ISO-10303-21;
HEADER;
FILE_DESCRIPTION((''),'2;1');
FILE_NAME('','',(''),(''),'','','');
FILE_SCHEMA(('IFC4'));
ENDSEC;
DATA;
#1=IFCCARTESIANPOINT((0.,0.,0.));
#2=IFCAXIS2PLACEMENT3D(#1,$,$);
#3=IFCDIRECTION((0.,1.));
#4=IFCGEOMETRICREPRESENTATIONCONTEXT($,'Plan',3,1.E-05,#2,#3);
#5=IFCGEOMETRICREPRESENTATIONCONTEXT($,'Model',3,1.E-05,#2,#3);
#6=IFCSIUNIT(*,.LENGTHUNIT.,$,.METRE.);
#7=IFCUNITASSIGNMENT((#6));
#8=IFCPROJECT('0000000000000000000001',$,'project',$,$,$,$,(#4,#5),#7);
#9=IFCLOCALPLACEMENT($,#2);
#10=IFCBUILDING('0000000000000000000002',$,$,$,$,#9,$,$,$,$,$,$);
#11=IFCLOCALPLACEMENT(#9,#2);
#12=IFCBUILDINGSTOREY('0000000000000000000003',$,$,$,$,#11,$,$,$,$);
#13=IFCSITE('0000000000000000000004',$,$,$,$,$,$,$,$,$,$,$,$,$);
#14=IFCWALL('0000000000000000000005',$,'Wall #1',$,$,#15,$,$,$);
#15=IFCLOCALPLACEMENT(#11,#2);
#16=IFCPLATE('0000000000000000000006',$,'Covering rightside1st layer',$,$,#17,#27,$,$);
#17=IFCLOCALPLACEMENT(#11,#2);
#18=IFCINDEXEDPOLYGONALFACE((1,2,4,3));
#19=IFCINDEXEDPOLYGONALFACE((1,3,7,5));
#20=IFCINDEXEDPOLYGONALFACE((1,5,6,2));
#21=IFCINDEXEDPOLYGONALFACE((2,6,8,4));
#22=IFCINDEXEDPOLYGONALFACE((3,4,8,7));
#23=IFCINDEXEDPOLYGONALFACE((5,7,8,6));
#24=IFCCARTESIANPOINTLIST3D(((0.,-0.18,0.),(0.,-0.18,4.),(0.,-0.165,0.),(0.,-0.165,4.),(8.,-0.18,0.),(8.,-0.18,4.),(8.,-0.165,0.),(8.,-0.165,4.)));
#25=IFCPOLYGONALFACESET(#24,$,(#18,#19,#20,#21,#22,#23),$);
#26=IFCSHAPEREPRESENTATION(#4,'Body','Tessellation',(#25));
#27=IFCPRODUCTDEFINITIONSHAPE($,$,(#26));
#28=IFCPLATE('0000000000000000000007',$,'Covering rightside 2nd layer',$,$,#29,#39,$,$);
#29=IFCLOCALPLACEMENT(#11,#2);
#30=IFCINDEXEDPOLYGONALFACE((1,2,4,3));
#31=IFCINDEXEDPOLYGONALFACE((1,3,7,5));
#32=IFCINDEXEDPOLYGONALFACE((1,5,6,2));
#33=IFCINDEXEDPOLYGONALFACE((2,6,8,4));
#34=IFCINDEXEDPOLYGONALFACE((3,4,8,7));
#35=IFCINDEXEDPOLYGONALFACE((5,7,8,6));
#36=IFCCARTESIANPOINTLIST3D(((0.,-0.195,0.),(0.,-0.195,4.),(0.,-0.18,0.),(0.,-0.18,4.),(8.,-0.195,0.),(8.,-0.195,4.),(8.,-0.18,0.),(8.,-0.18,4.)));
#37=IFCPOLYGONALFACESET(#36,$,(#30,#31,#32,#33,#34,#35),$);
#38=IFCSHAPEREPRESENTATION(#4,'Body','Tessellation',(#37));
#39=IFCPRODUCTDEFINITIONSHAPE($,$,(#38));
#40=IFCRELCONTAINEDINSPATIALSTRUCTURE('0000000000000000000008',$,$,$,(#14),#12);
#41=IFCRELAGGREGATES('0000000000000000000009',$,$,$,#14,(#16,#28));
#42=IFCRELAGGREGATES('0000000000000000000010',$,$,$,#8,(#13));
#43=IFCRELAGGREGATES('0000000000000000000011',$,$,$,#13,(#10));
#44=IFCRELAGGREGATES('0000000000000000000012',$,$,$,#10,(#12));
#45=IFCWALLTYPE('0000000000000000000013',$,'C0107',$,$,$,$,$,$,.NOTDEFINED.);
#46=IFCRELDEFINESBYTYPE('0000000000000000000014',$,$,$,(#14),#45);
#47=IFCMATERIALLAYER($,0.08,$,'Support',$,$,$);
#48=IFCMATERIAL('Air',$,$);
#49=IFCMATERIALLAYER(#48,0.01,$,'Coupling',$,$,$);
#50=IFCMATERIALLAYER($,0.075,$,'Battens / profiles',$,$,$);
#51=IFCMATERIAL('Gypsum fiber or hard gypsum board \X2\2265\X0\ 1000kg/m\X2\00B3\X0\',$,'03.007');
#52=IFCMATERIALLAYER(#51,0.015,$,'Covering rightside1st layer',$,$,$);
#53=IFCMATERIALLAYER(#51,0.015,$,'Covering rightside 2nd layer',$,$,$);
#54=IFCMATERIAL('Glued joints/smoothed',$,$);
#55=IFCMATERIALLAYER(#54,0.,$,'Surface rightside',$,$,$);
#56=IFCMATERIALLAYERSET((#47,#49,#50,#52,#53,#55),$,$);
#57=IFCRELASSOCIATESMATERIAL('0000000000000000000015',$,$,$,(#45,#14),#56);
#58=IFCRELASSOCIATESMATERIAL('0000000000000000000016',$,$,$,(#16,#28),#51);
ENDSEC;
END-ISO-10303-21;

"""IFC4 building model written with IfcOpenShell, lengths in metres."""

from ifc_helpers import new_model, si_unit, direction, frame, frame_2d, origin, place, context, project, spatial, rectangle, extrude, material, layer, layer_set, type_object, element, aggregate, save


model = new_model("IFC4")

# Units and contexts
plan_context = context("Plan", 3, precision=1e-05, world=origin(), true_north=direction((0.0, 1.0)))
model_context = context("Model", 3, precision=1e-05, world=origin(), true_north=direction((0.0, 1.0)))
ifc_project = project(units=[si_unit("LENGTHUNIT", "METRE")], contexts=[plan_context, model_context])

# Site, building, storey
site = spatial("IfcSite", under=ifc_project)
building_placement = place(None, origin())
building = spatial("IfcBuilding", under=site, at=building_placement)
storey_placement = place(building_placement, origin())
storey = spatial("IfcBuildingStorey", under=building, at=storey_placement)

# Wall, plates
ifc_layer_1 = layer(None, 0.08, Name="Support")
ifc_material_1 = material(Name="Air")
ifc_layer_2 = layer(ifc_material_1, 0.01, Name="Coupling")
ifc_layer_3 = layer(None, 0.075, Name="Battens / profiles")
ifc_material_2 = material(Name="Gypsum fiber or hard gypsum board ≥ 1000kg/m³", Category="03.007")
ifc_layer_4 = layer(ifc_material_2, 0.015, Name="Covering rightside1st layer")
ifc_layer_5 = layer(ifc_material_2, 0.015, Name="Covering rightside 2nd layer")
ifc_material_3 = material(Name="Glued joints/smoothed")
ifc_layer_6 = layer(ifc_material_3, 0.0, Name="Surface rightside")
ifc_layer_set = layer_set([ifc_layer_1, ifc_layer_2, ifc_layer_3, ifc_layer_4, ifc_layer_5, ifc_layer_6])
wall_type = type_object("IfcWallType", Name="C0107", PredefinedType="NOTDEFINED", material=ifc_layer_set)
wall_placement = place(None, frame((0.0, 0.0, 0.0), z_axis=(0.0, -1.0, 0.0), x_axis=(1.0, 0.0, 0.0)))
wall = element("IfcWall", 1, at=wall_placement, inside=storey, type_object=wall_type, material=ifc_layer_set, Name="Wall #1")
plate_1_placement = place(wall_placement, origin())
plate_1 = element("IfcPlate", 2, at=plate_1_placement, material=ifc_material_2, Name="Covering rightside1st layer", context=plan_context, shape_type="SweptSolid", body=[
    extrude(rectangle(XDim=8.0, YDim=4.0, at=frame_2d((4.0, 2.0), x_axis=(1.0, 0.0))), frame((0.0, 0.0, 0.165), z_axis=(0.0, 0.0, 1.0), x_axis=(1.0, 0.0, 0.0)), (0.0, 0.0, 1.0), 0.015),
])
plate_2_placement = place(wall_placement, origin())
plate_2 = element("IfcPlate", 3, at=plate_2_placement, material=ifc_material_2, Name="Covering rightside 2nd layer", context=plan_context, shape_type="SweptSolid", body=[
    extrude(rectangle(XDim=8.0, YDim=4.0, at=frame_2d((4.0, 2.0), x_axis=(1.0, 0.0))), frame((0.0, 0.0, 0.18), z_axis=(0.0, 0.0, 1.0), x_axis=(1.0, 0.0, 0.0)), (0.0, 0.0, 1.0), 0.015),
])
aggregate(wall, [plate_1, plate_2])

save(model, "model.ifc")
